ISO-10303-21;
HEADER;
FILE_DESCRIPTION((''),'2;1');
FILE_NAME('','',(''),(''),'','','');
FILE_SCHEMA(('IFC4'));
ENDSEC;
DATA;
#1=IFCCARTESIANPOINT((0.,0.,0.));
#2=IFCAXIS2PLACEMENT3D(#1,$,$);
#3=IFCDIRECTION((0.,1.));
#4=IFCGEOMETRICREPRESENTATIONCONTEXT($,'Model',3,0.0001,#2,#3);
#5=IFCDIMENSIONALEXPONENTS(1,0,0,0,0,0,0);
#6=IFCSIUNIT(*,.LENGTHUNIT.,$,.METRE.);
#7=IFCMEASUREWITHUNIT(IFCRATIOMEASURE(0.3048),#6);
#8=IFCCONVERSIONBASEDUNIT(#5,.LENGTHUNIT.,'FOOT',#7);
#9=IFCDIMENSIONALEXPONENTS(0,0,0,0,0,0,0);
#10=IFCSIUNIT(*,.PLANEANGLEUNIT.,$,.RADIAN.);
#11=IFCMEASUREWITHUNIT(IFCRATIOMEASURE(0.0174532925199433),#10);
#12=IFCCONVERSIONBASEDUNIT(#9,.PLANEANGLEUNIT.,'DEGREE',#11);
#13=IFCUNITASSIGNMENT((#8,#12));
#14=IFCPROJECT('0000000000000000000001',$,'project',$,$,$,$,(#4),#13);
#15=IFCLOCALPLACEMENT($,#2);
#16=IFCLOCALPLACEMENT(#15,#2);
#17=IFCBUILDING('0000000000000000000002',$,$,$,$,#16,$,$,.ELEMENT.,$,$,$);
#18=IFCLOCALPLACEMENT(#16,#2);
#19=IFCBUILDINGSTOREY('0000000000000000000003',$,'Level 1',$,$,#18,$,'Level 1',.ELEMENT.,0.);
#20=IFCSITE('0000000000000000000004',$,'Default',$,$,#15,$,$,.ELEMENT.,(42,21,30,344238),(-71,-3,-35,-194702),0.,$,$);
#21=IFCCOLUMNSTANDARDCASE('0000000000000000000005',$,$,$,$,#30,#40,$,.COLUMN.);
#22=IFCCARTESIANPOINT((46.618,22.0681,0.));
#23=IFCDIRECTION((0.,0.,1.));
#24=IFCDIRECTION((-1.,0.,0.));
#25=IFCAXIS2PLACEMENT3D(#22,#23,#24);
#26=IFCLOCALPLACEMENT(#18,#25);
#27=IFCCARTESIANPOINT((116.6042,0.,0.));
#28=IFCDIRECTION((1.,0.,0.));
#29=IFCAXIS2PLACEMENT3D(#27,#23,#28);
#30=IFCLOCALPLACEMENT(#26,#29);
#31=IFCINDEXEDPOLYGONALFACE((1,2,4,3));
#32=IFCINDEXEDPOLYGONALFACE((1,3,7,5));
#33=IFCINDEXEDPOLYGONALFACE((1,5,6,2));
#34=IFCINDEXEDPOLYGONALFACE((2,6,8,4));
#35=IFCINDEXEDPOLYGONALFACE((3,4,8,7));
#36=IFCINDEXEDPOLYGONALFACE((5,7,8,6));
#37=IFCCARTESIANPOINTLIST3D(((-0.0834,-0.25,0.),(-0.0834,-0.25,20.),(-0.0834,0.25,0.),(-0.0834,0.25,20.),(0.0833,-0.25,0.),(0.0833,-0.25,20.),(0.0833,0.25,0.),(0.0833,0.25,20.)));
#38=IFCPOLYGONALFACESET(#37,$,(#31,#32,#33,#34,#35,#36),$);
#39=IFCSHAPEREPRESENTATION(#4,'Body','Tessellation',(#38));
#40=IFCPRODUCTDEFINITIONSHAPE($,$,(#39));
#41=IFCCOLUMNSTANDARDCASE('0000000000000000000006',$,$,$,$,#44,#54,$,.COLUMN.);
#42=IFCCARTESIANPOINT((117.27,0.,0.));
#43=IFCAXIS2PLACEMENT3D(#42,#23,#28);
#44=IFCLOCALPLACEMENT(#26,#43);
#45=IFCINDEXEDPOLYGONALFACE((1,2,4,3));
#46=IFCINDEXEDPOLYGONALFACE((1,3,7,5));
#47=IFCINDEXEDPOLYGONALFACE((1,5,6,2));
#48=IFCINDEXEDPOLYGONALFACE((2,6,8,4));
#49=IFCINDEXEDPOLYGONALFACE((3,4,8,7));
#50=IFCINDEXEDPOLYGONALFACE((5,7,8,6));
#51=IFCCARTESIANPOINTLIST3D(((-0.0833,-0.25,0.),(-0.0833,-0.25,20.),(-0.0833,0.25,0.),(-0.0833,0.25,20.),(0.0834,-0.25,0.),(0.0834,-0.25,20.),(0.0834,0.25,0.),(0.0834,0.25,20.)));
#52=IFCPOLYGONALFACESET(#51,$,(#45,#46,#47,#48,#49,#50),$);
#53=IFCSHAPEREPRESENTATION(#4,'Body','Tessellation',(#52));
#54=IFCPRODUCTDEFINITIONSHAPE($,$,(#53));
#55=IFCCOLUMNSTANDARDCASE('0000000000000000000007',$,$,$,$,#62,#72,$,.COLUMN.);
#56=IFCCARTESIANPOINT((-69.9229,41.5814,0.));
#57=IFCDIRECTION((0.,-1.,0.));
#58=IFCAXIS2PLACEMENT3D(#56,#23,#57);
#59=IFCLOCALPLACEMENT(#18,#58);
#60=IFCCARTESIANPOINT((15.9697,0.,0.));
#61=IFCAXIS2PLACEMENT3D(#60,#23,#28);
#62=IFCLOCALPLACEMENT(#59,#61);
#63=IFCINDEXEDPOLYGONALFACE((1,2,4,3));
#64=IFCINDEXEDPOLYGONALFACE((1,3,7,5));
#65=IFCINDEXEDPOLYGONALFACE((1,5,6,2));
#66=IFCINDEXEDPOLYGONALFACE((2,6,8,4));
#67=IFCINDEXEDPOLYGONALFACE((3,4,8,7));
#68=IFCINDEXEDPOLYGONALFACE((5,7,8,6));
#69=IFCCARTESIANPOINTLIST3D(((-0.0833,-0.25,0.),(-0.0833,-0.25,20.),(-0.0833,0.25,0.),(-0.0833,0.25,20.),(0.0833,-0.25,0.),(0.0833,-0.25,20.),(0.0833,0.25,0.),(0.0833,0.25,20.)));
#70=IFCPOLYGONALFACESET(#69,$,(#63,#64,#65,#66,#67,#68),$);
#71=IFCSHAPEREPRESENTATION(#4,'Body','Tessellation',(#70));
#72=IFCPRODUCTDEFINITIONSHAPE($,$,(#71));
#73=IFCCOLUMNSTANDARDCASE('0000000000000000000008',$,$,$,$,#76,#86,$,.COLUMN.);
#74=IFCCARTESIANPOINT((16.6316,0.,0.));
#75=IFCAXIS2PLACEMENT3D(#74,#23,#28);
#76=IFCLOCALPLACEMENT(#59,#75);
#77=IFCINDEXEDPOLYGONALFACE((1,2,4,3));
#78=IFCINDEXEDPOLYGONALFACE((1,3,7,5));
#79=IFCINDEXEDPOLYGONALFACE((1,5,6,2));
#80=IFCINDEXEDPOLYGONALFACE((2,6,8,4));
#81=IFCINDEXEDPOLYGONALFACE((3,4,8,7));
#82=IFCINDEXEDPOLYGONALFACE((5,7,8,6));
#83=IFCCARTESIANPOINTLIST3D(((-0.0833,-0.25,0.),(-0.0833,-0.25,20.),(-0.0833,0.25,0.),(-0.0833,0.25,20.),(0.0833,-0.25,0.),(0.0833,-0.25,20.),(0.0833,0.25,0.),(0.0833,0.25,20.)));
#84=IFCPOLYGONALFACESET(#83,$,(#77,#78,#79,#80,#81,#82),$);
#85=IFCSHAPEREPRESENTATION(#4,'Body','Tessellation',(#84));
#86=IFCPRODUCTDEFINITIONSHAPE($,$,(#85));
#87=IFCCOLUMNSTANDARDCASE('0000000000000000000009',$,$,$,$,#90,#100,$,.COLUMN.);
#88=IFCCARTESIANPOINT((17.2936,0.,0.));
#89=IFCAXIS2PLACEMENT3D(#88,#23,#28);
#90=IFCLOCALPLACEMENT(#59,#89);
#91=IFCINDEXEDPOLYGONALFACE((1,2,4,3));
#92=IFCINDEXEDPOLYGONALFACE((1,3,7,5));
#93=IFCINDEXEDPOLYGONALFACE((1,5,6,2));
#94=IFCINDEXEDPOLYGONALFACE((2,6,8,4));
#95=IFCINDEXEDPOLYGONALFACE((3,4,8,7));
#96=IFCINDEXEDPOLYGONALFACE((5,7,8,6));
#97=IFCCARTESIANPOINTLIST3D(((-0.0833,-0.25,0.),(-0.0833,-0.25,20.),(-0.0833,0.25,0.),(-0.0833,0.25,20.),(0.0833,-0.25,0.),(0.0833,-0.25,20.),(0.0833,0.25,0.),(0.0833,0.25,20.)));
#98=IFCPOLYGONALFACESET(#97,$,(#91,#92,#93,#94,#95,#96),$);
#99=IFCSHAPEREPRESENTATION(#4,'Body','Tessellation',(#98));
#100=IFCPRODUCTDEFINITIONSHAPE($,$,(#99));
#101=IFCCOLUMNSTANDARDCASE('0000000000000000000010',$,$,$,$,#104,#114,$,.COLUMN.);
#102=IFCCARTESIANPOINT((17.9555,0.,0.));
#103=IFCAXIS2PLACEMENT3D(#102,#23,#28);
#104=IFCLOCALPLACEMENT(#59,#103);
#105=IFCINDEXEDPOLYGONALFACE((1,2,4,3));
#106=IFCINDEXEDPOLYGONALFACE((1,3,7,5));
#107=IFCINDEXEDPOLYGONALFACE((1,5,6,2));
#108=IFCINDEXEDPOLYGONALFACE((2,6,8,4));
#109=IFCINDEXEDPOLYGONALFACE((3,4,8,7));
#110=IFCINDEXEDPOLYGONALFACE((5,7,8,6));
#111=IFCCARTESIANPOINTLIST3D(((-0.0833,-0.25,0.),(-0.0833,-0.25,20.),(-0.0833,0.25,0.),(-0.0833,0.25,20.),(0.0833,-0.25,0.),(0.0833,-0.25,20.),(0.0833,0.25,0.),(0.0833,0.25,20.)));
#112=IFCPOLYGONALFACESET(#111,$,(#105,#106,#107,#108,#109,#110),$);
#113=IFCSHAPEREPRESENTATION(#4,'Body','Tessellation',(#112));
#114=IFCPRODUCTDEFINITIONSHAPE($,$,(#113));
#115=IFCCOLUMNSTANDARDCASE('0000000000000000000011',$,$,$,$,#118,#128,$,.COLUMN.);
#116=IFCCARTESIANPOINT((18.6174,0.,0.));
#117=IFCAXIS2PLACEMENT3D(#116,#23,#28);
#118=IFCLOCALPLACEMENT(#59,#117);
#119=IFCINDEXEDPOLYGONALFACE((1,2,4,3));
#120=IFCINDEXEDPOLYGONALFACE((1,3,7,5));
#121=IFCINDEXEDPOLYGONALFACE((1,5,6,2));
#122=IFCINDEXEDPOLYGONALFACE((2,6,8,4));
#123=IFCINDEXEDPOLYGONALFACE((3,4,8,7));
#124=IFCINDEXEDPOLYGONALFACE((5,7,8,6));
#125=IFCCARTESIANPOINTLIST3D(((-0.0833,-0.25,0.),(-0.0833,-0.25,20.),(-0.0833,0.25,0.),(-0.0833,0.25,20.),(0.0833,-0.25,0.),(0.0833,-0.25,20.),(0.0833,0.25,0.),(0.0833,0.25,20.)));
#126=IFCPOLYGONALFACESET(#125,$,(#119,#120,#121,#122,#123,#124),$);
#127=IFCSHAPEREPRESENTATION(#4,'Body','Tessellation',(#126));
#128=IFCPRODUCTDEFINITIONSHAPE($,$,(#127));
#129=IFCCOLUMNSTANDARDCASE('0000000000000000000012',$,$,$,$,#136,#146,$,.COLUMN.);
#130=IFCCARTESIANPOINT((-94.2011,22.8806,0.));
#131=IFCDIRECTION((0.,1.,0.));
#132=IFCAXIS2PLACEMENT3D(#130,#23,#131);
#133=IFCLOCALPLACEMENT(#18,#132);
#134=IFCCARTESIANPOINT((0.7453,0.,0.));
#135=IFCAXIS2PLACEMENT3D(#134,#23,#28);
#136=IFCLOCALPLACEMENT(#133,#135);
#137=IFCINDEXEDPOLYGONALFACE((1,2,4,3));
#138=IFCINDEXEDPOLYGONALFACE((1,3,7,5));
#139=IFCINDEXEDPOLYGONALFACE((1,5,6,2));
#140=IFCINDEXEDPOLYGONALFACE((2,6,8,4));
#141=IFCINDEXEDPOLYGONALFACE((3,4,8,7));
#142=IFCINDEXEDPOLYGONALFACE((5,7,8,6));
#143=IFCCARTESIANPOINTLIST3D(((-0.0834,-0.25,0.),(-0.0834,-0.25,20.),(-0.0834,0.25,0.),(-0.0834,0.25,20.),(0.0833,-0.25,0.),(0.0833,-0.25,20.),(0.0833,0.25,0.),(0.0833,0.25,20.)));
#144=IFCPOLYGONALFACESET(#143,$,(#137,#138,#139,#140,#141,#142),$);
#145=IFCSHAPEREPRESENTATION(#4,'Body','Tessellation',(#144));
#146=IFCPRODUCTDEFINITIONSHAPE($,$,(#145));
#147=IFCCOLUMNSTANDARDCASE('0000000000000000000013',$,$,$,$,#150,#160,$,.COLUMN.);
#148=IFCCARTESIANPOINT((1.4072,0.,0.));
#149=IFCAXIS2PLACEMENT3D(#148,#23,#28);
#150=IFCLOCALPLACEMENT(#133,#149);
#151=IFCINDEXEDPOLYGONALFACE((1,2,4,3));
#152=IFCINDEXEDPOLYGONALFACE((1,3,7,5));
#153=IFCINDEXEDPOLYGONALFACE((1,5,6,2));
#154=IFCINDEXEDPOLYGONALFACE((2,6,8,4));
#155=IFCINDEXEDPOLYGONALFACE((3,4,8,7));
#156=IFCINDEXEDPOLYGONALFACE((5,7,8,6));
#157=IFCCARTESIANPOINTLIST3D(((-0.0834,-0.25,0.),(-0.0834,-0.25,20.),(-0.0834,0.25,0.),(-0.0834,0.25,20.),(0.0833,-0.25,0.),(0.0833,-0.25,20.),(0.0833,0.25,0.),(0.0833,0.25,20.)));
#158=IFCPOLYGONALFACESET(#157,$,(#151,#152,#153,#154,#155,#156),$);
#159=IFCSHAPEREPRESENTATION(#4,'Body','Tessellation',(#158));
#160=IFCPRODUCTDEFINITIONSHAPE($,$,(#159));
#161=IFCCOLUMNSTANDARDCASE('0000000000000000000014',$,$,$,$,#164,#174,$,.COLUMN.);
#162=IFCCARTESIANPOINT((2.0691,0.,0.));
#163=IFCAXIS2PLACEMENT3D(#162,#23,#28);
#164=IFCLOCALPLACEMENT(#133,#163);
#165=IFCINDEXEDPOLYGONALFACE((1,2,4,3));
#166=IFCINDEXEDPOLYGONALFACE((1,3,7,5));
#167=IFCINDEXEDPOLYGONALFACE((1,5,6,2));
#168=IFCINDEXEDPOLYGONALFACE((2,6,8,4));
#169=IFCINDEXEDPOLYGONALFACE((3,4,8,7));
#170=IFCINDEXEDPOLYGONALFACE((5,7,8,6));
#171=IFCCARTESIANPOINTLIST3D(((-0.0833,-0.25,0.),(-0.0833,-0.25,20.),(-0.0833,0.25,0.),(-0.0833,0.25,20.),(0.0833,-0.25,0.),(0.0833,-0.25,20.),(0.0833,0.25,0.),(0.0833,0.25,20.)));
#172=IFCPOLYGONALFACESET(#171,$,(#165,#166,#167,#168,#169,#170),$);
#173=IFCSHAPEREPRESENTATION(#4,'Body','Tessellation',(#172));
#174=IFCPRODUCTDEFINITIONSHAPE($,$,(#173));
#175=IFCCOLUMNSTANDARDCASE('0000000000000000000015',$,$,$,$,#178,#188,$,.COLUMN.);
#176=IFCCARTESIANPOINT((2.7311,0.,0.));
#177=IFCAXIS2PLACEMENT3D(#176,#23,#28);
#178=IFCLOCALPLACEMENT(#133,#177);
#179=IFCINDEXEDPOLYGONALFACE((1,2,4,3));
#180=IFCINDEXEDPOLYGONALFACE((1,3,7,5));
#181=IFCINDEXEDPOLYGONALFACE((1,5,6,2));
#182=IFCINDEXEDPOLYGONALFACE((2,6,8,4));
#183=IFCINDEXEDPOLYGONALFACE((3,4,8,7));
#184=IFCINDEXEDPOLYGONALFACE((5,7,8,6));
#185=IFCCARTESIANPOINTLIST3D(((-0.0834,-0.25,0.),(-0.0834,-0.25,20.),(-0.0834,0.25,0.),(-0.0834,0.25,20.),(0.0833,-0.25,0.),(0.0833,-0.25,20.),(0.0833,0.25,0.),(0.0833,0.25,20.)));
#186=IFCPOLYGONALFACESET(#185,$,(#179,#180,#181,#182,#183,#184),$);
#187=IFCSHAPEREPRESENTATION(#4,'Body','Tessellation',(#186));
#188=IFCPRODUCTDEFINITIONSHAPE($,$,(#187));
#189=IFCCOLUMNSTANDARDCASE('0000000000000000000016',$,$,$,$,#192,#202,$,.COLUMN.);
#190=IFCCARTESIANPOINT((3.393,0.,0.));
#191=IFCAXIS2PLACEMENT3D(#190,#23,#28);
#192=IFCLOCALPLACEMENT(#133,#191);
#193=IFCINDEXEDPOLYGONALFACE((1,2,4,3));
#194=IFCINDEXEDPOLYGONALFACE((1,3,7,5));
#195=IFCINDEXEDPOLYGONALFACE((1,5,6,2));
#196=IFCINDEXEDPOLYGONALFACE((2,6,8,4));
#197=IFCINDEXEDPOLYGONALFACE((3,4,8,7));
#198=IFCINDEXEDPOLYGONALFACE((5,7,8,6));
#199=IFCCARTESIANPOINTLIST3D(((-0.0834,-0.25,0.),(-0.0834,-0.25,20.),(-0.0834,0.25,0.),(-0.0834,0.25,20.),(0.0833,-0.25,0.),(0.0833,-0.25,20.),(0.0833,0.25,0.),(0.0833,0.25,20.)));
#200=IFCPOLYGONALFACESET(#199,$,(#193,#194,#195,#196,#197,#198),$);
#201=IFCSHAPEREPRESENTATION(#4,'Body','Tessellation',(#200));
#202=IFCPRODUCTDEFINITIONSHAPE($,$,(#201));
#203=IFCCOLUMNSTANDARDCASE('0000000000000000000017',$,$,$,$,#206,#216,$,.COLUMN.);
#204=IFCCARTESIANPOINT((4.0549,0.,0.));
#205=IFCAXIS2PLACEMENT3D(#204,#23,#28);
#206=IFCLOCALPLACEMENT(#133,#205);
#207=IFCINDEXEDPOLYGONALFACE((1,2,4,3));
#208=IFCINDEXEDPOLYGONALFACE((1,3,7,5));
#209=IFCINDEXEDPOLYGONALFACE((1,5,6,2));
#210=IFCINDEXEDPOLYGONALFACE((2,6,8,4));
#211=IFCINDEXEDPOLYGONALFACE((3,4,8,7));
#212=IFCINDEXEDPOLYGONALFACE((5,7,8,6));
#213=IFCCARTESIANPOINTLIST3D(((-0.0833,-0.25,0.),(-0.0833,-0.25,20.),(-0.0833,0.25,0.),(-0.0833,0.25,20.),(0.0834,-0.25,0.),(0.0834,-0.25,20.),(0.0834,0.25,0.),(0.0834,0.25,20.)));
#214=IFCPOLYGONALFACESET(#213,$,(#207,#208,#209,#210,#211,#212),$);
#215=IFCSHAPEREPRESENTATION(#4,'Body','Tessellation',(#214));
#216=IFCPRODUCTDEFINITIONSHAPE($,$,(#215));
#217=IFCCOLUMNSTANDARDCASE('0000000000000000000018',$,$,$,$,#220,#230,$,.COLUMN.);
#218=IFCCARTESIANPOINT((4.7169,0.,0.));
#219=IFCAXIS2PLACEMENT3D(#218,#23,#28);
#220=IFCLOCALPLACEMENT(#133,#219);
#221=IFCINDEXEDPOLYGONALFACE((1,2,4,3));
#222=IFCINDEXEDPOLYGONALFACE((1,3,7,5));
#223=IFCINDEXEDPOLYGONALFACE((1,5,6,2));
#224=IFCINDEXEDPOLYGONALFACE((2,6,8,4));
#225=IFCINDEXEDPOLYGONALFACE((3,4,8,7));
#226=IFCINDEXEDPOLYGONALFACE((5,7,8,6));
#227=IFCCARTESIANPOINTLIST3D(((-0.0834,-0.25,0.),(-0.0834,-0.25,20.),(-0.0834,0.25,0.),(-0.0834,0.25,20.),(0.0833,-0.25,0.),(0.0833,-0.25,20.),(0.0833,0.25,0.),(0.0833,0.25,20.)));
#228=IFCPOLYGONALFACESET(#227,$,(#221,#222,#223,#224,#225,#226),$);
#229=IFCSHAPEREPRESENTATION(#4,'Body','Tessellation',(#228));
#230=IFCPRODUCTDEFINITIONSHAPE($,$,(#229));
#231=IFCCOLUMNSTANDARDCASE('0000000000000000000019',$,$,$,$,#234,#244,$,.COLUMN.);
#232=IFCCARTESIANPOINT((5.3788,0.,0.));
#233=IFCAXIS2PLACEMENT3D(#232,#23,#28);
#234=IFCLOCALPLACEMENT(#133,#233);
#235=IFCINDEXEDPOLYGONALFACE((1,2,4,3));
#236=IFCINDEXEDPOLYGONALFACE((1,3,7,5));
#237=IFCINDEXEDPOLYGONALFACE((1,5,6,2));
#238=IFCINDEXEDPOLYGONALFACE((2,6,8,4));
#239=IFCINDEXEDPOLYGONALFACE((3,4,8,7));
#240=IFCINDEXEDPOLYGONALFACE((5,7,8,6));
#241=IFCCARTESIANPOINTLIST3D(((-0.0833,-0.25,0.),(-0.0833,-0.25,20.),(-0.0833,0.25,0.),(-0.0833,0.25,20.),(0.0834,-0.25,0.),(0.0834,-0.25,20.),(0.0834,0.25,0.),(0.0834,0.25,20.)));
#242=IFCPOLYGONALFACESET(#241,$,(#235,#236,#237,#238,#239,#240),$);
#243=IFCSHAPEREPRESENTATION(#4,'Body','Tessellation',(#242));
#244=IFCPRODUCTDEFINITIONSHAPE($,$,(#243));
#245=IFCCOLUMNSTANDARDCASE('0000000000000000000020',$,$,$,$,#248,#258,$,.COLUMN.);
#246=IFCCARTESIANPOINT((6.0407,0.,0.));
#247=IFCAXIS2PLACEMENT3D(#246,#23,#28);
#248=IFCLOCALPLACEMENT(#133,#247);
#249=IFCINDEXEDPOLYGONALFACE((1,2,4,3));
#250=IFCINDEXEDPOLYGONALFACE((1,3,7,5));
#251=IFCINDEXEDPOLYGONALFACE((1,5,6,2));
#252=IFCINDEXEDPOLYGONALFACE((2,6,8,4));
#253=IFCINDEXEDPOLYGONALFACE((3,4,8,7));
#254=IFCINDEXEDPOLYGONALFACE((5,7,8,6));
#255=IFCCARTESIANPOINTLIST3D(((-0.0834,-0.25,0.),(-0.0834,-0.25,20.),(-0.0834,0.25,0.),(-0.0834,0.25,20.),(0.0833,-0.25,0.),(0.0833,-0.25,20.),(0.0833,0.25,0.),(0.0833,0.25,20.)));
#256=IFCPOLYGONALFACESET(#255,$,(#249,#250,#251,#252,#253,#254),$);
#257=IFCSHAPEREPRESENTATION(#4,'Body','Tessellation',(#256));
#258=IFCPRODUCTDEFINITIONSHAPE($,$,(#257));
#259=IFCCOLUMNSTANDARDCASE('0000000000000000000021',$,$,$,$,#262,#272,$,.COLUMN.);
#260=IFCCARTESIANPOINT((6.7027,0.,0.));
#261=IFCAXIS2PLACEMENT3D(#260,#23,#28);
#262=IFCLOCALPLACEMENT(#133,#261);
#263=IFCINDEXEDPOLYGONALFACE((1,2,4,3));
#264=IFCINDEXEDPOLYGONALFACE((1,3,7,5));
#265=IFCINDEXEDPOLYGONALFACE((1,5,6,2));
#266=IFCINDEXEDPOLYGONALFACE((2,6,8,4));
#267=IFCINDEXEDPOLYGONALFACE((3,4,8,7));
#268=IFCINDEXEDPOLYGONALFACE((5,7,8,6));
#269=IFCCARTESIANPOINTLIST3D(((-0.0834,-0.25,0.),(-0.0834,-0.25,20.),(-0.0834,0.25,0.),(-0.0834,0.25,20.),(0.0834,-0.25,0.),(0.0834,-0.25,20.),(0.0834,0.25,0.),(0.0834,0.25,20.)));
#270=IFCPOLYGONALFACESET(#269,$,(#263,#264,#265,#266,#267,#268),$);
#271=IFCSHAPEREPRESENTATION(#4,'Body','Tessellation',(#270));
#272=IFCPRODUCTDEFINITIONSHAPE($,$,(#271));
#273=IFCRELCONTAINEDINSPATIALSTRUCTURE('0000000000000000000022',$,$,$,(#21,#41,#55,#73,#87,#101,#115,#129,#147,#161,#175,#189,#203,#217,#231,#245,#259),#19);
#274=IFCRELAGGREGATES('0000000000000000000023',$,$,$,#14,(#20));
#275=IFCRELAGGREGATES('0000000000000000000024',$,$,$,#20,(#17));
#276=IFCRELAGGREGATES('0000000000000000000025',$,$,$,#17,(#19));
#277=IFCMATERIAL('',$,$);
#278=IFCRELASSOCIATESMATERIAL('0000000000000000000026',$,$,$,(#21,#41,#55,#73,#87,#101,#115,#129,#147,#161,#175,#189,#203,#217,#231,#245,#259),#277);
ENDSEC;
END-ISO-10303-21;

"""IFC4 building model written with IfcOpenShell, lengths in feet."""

from ifc_helpers import new_model, entity, si_unit, converted_unit, direction, frame, origin, place, context, project, spatial, rectangle, extrude, material, element, save


model = new_model("IFC4")

# Units and contexts
model_context = context("Model", 3, precision=0.0001, world=origin(), true_north=direction((0.0, 1.0)))
ifc_project = project(units=[converted_unit("LENGTHUNIT", "FOOT", entity("IfcRatioMeasure", 0.3048), si_unit("LENGTHUNIT", "METRE"), dimensions=[1, 0, 0, 0, 0, 0, 0]), converted_unit("PLANEANGLEUNIT", "DEGREE", entity("IfcRatioMeasure", 0.0174532925199433), si_unit("PLANEANGLEUNIT", "RADIAN"), dimensions=[0, 0, 0, 0, 0, 0, 0])], contexts=[model_context])

# Site, building, storey
site_placement = place(None, origin())
site = spatial("IfcSite", under=ifc_project, at=site_placement, Name="Default", CompositionType="ELEMENT", RefLatitude=(42, 21, 30, 344238), RefLongitude=(-71, -3, -35, -194702), RefElevation=0.0)
building_placement = place(site_placement, origin())
building = spatial("IfcBuilding", under=site, at=building_placement, CompositionType="ELEMENT")
storey_placement = place(building_placement, origin())
storey = spatial("IfcBuildingStorey", under=building, at=storey_placement, Name="Level 1", LongName="Level 1", CompositionType="ELEMENT", Elevation=0.0)

# Columns
ifc_material_1 = material(Name="")
placement_1 = place(storey_placement, frame((46.618, 22.0681, 0.0), z_axis=(0.0, 0.0, 1.0), x_axis=(-1.0, 0.0, 0.0)))
for number, where, z_axis, x_axis in (
    (1, (116.6042, 0.0, 0.0), (0.0, 0.0, 1.0), (1.0, 0.0, 0.0)),
    (2, (117.27, 0.0, 0.0), (0.0, 0.0, 1.0), (1.0, 0.0, 0.0)),
):
    element("IfcColumnStandardCase", number, at=place(placement_1, frame(where, z_axis=z_axis, x_axis=x_axis)), inside=storey, material=ifc_material_1, PredefinedType="COLUMN", context=model_context, shape_type="SweptSolid", body=[
        extrude(rectangle(XDim=0.1667, YDim=0.5), origin(), (0.0, 0.0, 1.0), 20.0),
    ])
placement_2 = place(storey_placement, frame((-69.9229, 41.5814, 0.0), z_axis=(0.0, 0.0, 1.0), x_axis=(0.0, -1.0, 0.0)))
for number, where, z_axis, x_axis in (
    (3, (15.9697, 0.0, 0.0), (0.0, 0.0, 1.0), (1.0, 0.0, 0.0)),
    (4, (16.6316, 0.0, 0.0), (0.0, 0.0, 1.0), (1.0, 0.0, 0.0)),
    (5, (17.2936, 0.0, 0.0), (0.0, 0.0, 1.0), (1.0, 0.0, 0.0)),
    (6, (17.9555, 0.0, 0.0), (0.0, 0.0, 1.0), (1.0, 0.0, 0.0)),
    (7, (18.6174, 0.0, 0.0), (0.0, 0.0, 1.0), (1.0, 0.0, 0.0)),
):
    element("IfcColumnStandardCase", number, at=place(placement_2, frame(where, z_axis=z_axis, x_axis=x_axis)), inside=storey, material=ifc_material_1, PredefinedType="COLUMN", context=model_context, shape_type="SweptSolid", body=[
        extrude(rectangle(XDim=0.1667, YDim=0.5), origin(), (0.0, 0.0, 1.0), 20.0),
    ])
wall_1_placement = place(storey_placement, frame((-94.2011, 22.8806, 0.0), z_axis=(0.0, 0.0, 1.0), x_axis=(0.0, 1.0, 0.0)))
for number, where, z_axis, x_axis in (
    (8, (0.7453, 0.0, 0.0), (0.0, 0.0, 1.0), (1.0, 0.0, 0.0)),
    (9, (1.4072, 0.0, 0.0), (0.0, 0.0, 1.0), (1.0, 0.0, 0.0)),
    (10, (2.0691, 0.0, 0.0), (0.0, 0.0, 1.0), (1.0, 0.0, 0.0)),
    (11, (2.7311, 0.0, 0.0), (0.0, 0.0, 1.0), (1.0, 0.0, 0.0)),
    (12, (3.393, 0.0, 0.0), (0.0, 0.0, 1.0), (1.0, 0.0, 0.0)),
    (13, (4.0549, 0.0, 0.0), (0.0, 0.0, 1.0), (1.0, 0.0, 0.0)),
    (14, (4.7169, 0.0, 0.0), (0.0, 0.0, 1.0), (1.0, 0.0, 0.0)),
    (15, (5.3788, 0.0, 0.0), (0.0, 0.0, 1.0), (1.0, 0.0, 0.0)),
    (16, (6.0407, 0.0, 0.0), (0.0, 0.0, 1.0), (1.0, 0.0, 0.0)),
    (17, (6.7027, 0.0, 0.0), (0.0, 0.0, 1.0), (1.0, 0.0, 0.0)),
):
    element("IfcColumnStandardCase", number, at=place(wall_1_placement, frame(where, z_axis=z_axis, x_axis=x_axis)), inside=storey, material=ifc_material_1, PredefinedType="COLUMN", context=model_context, shape_type="SweptSolid", body=[
        extrude(rectangle(XDim=0.1667, YDim=0.5), origin(), (0.0, 0.0, 1.0), 20.0),
    ])

save(model, "model.ifc")
